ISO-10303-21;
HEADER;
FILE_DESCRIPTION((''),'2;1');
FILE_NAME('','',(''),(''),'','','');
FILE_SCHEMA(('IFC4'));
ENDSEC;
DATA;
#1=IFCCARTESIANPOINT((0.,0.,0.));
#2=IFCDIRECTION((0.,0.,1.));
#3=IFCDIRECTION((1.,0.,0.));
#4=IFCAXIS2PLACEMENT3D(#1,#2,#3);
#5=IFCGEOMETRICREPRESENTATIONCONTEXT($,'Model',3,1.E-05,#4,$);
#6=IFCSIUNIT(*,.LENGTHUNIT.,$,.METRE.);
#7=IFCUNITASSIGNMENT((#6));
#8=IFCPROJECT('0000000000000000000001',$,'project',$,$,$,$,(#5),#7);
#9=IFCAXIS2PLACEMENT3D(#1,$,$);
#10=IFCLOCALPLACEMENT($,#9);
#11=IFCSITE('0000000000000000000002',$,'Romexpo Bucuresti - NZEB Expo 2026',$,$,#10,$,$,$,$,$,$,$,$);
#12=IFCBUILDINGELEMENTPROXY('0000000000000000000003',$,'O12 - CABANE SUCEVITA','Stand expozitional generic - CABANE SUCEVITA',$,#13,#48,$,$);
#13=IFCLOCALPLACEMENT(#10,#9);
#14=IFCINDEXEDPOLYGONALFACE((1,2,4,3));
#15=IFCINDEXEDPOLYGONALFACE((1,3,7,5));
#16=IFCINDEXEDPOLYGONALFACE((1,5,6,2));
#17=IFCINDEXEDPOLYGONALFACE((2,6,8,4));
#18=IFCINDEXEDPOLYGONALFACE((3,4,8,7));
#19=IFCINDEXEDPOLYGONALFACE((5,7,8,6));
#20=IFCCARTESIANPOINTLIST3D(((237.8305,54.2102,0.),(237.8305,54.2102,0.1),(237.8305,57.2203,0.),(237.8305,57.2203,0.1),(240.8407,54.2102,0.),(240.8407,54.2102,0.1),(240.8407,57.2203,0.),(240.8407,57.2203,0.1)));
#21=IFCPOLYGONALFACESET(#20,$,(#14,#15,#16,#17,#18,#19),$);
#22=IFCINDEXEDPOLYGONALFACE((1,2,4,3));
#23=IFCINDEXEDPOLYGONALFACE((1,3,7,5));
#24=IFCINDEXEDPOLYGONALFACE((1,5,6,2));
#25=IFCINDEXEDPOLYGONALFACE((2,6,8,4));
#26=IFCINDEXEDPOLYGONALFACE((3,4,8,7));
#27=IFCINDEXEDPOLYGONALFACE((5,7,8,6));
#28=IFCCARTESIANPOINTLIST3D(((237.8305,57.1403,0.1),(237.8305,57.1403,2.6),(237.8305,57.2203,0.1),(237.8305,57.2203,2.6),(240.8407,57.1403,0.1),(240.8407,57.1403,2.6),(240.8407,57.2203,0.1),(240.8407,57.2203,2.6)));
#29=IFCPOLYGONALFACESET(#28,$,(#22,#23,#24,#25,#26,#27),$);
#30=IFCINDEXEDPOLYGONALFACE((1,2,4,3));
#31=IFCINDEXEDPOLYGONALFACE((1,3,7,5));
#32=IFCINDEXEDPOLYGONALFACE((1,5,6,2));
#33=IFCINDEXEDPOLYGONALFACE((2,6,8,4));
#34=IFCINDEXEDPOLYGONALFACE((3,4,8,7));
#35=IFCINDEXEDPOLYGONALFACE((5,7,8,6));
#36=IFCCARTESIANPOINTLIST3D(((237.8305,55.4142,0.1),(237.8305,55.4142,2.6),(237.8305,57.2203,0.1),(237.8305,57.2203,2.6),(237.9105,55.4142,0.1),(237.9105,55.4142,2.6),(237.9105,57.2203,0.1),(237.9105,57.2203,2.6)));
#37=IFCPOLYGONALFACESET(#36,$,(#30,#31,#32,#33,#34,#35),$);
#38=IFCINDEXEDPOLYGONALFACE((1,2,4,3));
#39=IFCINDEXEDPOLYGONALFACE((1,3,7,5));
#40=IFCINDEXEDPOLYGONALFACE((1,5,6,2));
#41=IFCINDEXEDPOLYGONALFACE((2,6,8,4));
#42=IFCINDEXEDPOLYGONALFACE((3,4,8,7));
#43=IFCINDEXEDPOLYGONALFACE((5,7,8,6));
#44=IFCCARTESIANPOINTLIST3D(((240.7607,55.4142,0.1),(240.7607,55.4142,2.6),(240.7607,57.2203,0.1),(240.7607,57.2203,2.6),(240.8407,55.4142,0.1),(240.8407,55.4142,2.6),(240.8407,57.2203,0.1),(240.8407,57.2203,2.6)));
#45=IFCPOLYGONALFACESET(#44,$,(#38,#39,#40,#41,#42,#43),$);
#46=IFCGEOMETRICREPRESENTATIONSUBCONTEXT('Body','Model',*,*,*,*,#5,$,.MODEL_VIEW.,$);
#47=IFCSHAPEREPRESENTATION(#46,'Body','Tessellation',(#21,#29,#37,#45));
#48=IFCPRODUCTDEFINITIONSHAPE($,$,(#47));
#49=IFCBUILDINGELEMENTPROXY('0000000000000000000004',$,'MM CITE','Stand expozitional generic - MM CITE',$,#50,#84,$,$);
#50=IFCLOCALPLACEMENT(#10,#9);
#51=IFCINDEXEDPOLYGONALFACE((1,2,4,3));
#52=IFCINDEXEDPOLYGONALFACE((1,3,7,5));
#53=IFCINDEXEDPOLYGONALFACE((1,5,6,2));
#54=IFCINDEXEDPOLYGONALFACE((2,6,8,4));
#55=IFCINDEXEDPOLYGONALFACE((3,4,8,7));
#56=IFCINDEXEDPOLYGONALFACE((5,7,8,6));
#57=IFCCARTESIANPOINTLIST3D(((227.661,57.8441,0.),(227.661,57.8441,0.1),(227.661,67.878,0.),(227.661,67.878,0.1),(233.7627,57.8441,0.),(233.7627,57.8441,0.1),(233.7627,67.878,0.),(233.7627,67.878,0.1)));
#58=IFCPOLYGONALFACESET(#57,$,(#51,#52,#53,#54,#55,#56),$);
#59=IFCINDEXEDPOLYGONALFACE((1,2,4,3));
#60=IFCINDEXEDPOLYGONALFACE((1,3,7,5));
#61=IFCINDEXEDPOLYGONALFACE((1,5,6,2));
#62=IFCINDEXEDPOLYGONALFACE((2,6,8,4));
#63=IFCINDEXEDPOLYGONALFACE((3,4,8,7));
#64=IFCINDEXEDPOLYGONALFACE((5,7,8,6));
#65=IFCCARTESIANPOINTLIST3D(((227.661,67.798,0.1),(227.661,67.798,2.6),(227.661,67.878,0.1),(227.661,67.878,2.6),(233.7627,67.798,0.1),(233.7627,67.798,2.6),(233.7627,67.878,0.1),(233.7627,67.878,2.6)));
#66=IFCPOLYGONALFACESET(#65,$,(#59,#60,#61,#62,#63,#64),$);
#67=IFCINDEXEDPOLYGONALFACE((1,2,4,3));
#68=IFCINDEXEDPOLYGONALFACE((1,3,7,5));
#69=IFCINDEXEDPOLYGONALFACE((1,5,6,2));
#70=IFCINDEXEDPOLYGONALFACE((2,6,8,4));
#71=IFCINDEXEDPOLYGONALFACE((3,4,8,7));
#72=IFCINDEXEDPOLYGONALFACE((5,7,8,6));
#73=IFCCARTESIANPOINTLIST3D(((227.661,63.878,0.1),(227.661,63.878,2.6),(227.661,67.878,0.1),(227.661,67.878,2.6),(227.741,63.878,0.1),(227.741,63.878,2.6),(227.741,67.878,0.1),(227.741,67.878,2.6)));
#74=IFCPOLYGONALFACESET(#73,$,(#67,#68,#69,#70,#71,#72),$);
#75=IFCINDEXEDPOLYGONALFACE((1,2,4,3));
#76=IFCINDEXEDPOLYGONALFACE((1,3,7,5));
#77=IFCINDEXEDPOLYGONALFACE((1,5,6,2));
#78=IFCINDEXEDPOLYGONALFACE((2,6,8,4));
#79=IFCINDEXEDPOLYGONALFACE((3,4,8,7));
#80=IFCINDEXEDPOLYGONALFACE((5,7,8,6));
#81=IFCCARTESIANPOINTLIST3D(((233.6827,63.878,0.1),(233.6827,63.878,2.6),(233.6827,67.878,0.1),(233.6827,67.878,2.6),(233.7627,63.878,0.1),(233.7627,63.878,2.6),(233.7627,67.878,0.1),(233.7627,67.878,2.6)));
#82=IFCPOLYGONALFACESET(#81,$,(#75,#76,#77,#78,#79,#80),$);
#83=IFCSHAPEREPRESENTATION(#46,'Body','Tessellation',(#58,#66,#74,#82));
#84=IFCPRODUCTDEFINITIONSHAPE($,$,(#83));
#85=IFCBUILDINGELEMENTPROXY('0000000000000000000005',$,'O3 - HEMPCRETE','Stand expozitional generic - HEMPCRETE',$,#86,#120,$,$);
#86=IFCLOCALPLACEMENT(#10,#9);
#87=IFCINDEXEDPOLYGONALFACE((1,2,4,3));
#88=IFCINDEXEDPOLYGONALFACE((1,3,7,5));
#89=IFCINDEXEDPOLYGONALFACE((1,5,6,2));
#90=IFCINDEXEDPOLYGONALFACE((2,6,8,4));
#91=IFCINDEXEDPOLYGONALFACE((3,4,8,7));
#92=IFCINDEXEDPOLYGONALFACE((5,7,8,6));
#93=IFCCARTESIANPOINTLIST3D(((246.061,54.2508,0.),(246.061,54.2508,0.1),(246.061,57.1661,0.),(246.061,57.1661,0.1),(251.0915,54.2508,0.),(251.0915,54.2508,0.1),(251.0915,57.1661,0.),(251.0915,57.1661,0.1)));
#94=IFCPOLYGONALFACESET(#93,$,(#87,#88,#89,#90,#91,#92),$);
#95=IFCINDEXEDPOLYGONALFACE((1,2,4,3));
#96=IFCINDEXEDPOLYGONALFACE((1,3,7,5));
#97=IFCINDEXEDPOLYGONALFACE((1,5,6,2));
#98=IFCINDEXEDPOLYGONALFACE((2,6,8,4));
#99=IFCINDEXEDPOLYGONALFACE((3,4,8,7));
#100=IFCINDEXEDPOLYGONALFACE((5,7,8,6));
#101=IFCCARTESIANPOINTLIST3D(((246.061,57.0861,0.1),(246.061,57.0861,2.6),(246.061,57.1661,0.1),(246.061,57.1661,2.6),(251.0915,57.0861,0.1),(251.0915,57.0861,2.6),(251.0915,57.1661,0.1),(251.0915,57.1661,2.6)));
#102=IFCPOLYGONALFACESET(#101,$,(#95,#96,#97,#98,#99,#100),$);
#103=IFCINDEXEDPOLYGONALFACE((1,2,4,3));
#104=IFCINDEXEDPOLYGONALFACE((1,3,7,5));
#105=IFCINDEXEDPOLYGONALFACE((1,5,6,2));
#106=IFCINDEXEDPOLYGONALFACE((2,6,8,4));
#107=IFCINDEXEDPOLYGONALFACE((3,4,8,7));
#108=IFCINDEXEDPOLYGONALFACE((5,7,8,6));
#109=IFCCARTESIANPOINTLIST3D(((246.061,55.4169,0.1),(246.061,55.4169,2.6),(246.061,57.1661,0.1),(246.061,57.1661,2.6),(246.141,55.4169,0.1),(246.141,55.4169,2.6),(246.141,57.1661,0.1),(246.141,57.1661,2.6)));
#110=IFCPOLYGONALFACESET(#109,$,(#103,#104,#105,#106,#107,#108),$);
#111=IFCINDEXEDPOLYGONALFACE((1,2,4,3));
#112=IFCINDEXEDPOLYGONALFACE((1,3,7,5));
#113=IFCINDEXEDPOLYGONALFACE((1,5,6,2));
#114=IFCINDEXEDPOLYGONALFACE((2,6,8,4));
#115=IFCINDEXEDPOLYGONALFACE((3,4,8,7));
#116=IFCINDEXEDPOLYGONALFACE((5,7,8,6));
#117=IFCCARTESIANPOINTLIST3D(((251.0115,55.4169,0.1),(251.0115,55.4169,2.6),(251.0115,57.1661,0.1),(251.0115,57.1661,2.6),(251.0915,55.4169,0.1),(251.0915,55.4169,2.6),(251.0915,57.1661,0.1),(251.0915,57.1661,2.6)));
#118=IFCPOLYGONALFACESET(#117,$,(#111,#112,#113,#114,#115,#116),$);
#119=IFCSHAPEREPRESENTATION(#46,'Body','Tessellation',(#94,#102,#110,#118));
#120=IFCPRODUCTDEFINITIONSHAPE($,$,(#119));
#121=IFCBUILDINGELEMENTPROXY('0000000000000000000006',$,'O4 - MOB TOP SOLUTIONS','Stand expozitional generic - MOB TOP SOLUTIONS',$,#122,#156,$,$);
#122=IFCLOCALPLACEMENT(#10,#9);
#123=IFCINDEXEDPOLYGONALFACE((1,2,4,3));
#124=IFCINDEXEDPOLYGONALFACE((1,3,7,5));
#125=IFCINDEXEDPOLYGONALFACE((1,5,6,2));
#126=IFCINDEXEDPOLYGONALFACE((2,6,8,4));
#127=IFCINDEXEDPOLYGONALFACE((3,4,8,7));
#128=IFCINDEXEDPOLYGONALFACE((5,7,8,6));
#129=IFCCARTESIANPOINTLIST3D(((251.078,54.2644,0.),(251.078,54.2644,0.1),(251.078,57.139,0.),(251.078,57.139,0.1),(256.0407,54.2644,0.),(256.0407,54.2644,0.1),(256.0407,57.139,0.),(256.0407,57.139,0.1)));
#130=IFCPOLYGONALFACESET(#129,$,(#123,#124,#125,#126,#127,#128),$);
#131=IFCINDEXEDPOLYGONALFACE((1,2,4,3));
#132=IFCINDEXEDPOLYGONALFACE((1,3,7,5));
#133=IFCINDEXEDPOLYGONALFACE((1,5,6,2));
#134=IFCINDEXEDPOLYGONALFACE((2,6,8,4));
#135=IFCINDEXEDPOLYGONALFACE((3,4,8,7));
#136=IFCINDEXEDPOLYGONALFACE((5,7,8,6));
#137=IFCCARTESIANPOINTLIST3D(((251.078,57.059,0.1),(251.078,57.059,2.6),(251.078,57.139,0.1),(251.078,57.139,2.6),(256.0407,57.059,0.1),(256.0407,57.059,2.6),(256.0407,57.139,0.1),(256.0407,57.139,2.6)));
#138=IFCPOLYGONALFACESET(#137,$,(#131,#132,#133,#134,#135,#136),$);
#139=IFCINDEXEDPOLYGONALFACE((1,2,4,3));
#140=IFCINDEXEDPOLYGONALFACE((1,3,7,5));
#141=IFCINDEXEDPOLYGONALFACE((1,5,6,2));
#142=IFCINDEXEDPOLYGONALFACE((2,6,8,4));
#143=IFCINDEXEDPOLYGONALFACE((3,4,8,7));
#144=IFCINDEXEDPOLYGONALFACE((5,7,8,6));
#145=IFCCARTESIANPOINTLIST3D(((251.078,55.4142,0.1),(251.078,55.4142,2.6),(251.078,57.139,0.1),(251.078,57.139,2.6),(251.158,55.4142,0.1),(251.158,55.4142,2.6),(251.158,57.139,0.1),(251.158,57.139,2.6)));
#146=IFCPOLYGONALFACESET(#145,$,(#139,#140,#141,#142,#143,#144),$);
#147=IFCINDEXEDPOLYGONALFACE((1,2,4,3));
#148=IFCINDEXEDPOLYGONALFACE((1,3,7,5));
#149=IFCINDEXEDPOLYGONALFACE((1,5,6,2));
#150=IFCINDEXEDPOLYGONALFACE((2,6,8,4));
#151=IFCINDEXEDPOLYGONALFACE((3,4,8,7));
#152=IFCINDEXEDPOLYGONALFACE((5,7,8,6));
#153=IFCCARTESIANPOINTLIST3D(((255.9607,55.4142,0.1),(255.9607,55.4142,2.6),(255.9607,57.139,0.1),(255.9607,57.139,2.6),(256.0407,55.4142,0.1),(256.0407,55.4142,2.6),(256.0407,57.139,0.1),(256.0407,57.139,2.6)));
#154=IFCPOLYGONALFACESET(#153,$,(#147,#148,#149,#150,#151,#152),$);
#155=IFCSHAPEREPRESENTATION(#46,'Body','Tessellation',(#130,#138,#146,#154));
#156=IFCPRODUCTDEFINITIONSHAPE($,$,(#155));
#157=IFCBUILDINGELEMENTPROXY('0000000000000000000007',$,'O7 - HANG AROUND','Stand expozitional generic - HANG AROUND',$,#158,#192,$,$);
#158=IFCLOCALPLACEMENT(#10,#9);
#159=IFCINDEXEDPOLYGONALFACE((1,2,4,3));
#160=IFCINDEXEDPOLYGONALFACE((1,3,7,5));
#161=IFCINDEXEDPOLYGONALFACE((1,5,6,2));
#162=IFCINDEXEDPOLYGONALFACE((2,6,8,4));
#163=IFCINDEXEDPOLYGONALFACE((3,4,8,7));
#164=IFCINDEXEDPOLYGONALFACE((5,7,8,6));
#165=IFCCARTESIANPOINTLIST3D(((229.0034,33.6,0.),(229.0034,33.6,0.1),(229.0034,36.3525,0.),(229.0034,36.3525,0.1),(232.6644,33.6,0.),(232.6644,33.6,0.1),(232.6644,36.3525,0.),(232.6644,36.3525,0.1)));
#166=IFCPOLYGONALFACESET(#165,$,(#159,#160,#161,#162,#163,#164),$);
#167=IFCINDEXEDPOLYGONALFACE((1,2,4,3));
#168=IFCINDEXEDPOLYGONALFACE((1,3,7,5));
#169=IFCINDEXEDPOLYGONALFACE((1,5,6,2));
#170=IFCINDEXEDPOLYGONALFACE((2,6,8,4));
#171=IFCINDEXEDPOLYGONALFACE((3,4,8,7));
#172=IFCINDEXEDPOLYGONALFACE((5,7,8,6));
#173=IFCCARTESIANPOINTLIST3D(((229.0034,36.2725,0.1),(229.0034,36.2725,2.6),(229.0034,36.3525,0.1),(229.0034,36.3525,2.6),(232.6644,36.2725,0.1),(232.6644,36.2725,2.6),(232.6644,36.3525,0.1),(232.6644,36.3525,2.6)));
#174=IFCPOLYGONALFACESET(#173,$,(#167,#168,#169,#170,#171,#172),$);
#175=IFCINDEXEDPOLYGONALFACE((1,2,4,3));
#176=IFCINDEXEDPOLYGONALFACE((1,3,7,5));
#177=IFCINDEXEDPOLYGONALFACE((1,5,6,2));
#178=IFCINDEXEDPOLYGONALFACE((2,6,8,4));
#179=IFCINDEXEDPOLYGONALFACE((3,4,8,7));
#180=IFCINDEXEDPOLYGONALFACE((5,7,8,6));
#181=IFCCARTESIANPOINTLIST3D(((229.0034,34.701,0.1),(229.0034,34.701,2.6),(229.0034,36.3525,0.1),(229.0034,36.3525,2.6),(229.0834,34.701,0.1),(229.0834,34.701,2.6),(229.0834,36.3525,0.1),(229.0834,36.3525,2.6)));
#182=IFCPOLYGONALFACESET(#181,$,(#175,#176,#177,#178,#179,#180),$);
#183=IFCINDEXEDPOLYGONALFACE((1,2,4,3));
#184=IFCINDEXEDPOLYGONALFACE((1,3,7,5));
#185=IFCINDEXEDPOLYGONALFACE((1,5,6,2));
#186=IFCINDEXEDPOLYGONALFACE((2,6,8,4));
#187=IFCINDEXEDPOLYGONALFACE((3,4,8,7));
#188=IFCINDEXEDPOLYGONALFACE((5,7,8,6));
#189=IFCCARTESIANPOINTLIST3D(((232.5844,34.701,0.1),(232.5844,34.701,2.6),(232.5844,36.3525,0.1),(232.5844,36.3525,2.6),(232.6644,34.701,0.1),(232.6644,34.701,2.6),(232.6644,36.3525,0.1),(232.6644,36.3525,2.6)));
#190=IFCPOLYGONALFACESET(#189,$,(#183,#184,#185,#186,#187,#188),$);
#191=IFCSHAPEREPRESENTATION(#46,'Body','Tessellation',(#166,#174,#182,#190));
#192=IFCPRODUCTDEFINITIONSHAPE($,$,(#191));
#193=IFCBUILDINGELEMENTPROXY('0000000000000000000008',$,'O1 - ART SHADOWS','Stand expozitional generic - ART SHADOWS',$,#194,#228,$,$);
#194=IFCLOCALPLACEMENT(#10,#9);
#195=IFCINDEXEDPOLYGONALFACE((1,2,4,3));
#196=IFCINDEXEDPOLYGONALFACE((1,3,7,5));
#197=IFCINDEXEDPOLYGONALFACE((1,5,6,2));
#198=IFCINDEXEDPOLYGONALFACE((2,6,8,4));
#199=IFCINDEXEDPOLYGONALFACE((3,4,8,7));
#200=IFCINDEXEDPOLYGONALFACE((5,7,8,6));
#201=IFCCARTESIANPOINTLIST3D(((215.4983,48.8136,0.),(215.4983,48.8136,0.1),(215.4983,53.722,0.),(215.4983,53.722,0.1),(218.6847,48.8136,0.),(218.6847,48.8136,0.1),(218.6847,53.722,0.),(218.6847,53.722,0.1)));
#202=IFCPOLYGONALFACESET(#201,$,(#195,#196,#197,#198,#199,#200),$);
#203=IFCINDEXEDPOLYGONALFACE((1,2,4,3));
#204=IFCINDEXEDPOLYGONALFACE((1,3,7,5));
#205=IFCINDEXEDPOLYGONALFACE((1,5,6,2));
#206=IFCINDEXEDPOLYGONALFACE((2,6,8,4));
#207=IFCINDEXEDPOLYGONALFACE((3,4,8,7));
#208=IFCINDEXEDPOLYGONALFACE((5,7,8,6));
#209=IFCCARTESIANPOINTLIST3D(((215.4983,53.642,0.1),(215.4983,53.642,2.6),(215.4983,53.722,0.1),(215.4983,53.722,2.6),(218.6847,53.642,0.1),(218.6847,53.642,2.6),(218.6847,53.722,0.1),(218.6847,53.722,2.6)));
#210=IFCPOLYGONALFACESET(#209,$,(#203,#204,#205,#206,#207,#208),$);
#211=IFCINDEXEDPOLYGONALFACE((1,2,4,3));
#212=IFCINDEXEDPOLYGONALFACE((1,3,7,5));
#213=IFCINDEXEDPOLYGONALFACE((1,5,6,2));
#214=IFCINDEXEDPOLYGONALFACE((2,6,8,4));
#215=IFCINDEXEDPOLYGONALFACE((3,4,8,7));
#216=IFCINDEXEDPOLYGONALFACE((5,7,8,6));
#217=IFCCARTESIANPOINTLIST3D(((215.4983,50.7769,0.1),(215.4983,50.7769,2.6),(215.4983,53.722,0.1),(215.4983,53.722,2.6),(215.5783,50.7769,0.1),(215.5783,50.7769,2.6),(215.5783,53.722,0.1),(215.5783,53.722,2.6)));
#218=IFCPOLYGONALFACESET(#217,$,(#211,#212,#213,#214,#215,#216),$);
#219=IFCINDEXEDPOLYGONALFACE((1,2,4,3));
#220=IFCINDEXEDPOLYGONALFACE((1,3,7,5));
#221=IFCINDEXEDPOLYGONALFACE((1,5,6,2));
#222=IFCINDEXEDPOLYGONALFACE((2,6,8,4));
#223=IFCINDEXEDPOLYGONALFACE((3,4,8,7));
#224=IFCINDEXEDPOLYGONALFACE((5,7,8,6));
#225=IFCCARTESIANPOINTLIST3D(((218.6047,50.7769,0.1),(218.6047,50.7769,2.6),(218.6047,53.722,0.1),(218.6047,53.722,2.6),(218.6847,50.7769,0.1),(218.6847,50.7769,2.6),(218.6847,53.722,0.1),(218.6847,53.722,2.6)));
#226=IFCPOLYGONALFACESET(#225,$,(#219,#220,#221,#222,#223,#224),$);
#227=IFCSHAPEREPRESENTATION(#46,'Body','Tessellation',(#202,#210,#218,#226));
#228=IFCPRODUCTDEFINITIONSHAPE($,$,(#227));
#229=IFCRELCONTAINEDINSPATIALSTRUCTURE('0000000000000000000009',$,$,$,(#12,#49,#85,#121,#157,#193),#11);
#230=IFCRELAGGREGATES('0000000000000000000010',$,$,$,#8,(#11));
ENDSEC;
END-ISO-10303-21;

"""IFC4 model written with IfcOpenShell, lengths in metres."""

from ifc_helpers import new_model, si_unit, frame, frame_2d, origin, origin_with_axes, place, context, subcontext, project, spatial, rectangle, extrude, element, save


model = new_model("IFC4")

# Units and contexts
model_context = context("Model", 3, precision=1e-05, world=origin_with_axes())
body_context = subcontext(model_context, "Body", "Model", "MODEL_VIEW")
ifc_project = project(units=[si_unit("LENGTHUNIT", "METRE")], contexts=[model_context])

# Site
site_placement = place(None, origin())
site = spatial("IfcSite", under=ifc_project, at=site_placement, Name="Romexpo Bucuresti - NZEB Expo 2026")

# Building element proxies
proxy_1_placement = place(site_placement, frame((237.8305, 54.2102, 0.0), z_axis=(0.0, 0.0, 1.0), x_axis=(1.0, 0.0, 0.0)))
element("IfcBuildingElementProxy", 1, at=proxy_1_placement, inside=site, Name="O12 - CABANE SUCEVITA", Description="Stand expozitional generic - CABANE SUCEVITA", context=body_context, shape_type="SweptSolid", body=[
    extrude(rectangle(XDim=3.0102, YDim=3.0102, at=frame_2d((1.5051, 1.5051))), origin(), (0.0, 0.0, 1.0), 0.1),
    extrude(rectangle(XDim=3.0102, YDim=0.08, at=frame_2d((1.5051, 2.9702))), frame((0.0, 0.0, 0.1)), (0.0, 0.0, 1.0), 2.5),
    extrude(rectangle(XDim=0.08, YDim=1.8061, at=frame_2d((0.04, 2.1071))), frame((0.0, 0.0, 0.1)), (0.0, 0.0, 1.0), 2.5),
    extrude(rectangle(XDim=0.08, YDim=1.8061, at=frame_2d((2.9702, 2.1071))), frame((0.0, 0.0, 0.1)), (0.0, 0.0, 1.0), 2.5),
])
proxy_2_placement = place(site_placement, frame((227.661, 57.8441, 0.0), z_axis=(0.0, 0.0, 1.0), x_axis=(1.0, 0.0, 0.0)))
element("IfcBuildingElementProxy", 2, at=proxy_2_placement, inside=site, Name="MM CITE", Description="Stand expozitional generic - MM CITE", context=body_context, shape_type="SweptSolid", body=[
    extrude(rectangle(XDim=6.1017, YDim=10.0339, at=frame_2d((3.0508, 5.0169))), origin(), (0.0, 0.0, 1.0), 0.1),
    extrude(rectangle(XDim=6.1017, YDim=0.08, at=frame_2d((3.0508, 9.9939))), frame((0.0, 0.0, 0.1)), (0.0, 0.0, 1.0), 2.5),
    extrude(rectangle(XDim=0.08, YDim=4.0, at=frame_2d((0.04, 8.0339))), frame((0.0, 0.0, 0.1)), (0.0, 0.0, 1.0), 2.5),
    extrude(rectangle(XDim=0.08, YDim=4.0, at=frame_2d((6.0617, 8.0339))), frame((0.0, 0.0, 0.1)), (0.0, 0.0, 1.0), 2.5),
])
proxy_3_placement = place(site_placement, frame((246.061, 54.2508, 0.0), z_axis=(0.0, 0.0, 1.0), x_axis=(1.0, 0.0, 0.0)))
element("IfcBuildingElementProxy", 3, at=proxy_3_placement, inside=site, Name="O3 - HEMPCRETE", Description="Stand expozitional generic - HEMPCRETE", context=body_context, shape_type="SweptSolid", body=[
    extrude(rectangle(XDim=5.0305, YDim=2.9153, at=frame_2d((2.5153, 1.4576))), origin(), (0.0, 0.0, 1.0), 0.1),
    extrude(rectangle(XDim=5.0305, YDim=0.08, at=frame_2d((2.5153, 2.8753))), frame((0.0, 0.0, 0.1)), (0.0, 0.0, 1.0), 2.5),
    extrude(rectangle(XDim=0.08, YDim=1.7492, at=frame_2d((0.04, 2.0407))), frame((0.0, 0.0, 0.1)), (0.0, 0.0, 1.0), 2.5),
    extrude(rectangle(XDim=0.08, YDim=1.7492, at=frame_2d((4.9905, 2.0407))), frame((0.0, 0.0, 0.1)), (0.0, 0.0, 1.0), 2.5),
])
proxy_4_placement = place(site_placement, frame((251.078, 54.2644, 0.0), z_axis=(0.0, 0.0, 1.0), x_axis=(1.0, 0.0, 0.0)))
element("IfcBuildingElementProxy", 4, at=proxy_4_placement, inside=site, Name="O4 - MOB TOP SOLUTIONS", Description="Stand expozitional generic - MOB TOP SOLUTIONS", context=body_context, shape_type="SweptSolid", body=[
    extrude(rectangle(XDim=4.9627, YDim=2.8746, at=frame_2d((2.4814, 1.4373))), origin(), (0.0, 0.0, 1.0), 0.1),
    extrude(rectangle(XDim=4.9627, YDim=0.08, at=frame_2d((2.4814, 2.8346))), frame((0.0, 0.0, 0.1)), (0.0, 0.0, 1.0), 2.5),
    extrude(rectangle(XDim=0.08, YDim=1.7247, at=frame_2d((0.04, 2.0122))), frame((0.0, 0.0, 0.1)), (0.0, 0.0, 1.0), 2.5),
    extrude(rectangle(XDim=0.08, YDim=1.7247, at=frame_2d((4.9227, 2.0122))), frame((0.0, 0.0, 0.1)), (0.0, 0.0, 1.0), 2.5),
])
proxy_5_placement = place(site_placement, frame((229.0034, 33.6, 0.0), z_axis=(0.0, 0.0, 1.0), x_axis=(1.0, 0.0, 0.0)))
element("IfcBuildingElementProxy", 5, at=proxy_5_placement, inside=site, Name="O7 - HANG AROUND", Description="Stand expozitional generic - HANG AROUND", context=body_context, shape_type="SweptSolid", body=[
    extrude(rectangle(XDim=3.661, YDim=2.7525, at=frame_2d((1.8305, 1.3763))), origin(), (0.0, 0.0, 1.0), 0.1),
    extrude(rectangle(XDim=3.661, YDim=0.08, at=frame_2d((1.8305, 2.7125))), frame((0.0, 0.0, 0.1)), (0.0, 0.0, 1.0), 2.5),
    extrude(rectangle(XDim=0.08, YDim=1.6515, at=frame_2d((0.04, 1.9268))), frame((0.0, 0.0, 0.1)), (0.0, 0.0, 1.0), 2.5),
    extrude(rectangle(XDim=0.08, YDim=1.6515, at=frame_2d((3.621, 1.9268))), frame((0.0, 0.0, 0.1)), (0.0, 0.0, 1.0), 2.5),
])
proxy_6_placement = place(site_placement, frame((215.4983, 48.8136, 0.0), z_axis=(0.0, 0.0, 1.0), x_axis=(1.0, 0.0, 0.0)))
element("IfcBuildingElementProxy", 6, at=proxy_6_placement, inside=site, Name="O1 - ART SHADOWS", Description="Stand expozitional generic - ART SHADOWS", context=body_context, shape_type="SweptSolid", body=[
    extrude(rectangle(XDim=3.1864, YDim=4.9085, at=frame_2d((1.5932, 2.4542))), origin(), (0.0, 0.0, 1.0), 0.1),
    extrude(rectangle(XDim=3.1864, YDim=0.08, at=frame_2d((1.5932, 4.8685))), frame((0.0, 0.0, 0.1)), (0.0, 0.0, 1.0), 2.5),
    extrude(rectangle(XDim=0.08, YDim=2.9451, at=frame_2d((0.04, 3.4359))), frame((0.0, 0.0, 0.1)), (0.0, 0.0, 1.0), 2.5),
    extrude(rectangle(XDim=0.08, YDim=2.9451, at=frame_2d((3.1464, 3.4359))), frame((0.0, 0.0, 0.1)), (0.0, 0.0, 1.0), 2.5),
])

save(model, "model.ifc")
